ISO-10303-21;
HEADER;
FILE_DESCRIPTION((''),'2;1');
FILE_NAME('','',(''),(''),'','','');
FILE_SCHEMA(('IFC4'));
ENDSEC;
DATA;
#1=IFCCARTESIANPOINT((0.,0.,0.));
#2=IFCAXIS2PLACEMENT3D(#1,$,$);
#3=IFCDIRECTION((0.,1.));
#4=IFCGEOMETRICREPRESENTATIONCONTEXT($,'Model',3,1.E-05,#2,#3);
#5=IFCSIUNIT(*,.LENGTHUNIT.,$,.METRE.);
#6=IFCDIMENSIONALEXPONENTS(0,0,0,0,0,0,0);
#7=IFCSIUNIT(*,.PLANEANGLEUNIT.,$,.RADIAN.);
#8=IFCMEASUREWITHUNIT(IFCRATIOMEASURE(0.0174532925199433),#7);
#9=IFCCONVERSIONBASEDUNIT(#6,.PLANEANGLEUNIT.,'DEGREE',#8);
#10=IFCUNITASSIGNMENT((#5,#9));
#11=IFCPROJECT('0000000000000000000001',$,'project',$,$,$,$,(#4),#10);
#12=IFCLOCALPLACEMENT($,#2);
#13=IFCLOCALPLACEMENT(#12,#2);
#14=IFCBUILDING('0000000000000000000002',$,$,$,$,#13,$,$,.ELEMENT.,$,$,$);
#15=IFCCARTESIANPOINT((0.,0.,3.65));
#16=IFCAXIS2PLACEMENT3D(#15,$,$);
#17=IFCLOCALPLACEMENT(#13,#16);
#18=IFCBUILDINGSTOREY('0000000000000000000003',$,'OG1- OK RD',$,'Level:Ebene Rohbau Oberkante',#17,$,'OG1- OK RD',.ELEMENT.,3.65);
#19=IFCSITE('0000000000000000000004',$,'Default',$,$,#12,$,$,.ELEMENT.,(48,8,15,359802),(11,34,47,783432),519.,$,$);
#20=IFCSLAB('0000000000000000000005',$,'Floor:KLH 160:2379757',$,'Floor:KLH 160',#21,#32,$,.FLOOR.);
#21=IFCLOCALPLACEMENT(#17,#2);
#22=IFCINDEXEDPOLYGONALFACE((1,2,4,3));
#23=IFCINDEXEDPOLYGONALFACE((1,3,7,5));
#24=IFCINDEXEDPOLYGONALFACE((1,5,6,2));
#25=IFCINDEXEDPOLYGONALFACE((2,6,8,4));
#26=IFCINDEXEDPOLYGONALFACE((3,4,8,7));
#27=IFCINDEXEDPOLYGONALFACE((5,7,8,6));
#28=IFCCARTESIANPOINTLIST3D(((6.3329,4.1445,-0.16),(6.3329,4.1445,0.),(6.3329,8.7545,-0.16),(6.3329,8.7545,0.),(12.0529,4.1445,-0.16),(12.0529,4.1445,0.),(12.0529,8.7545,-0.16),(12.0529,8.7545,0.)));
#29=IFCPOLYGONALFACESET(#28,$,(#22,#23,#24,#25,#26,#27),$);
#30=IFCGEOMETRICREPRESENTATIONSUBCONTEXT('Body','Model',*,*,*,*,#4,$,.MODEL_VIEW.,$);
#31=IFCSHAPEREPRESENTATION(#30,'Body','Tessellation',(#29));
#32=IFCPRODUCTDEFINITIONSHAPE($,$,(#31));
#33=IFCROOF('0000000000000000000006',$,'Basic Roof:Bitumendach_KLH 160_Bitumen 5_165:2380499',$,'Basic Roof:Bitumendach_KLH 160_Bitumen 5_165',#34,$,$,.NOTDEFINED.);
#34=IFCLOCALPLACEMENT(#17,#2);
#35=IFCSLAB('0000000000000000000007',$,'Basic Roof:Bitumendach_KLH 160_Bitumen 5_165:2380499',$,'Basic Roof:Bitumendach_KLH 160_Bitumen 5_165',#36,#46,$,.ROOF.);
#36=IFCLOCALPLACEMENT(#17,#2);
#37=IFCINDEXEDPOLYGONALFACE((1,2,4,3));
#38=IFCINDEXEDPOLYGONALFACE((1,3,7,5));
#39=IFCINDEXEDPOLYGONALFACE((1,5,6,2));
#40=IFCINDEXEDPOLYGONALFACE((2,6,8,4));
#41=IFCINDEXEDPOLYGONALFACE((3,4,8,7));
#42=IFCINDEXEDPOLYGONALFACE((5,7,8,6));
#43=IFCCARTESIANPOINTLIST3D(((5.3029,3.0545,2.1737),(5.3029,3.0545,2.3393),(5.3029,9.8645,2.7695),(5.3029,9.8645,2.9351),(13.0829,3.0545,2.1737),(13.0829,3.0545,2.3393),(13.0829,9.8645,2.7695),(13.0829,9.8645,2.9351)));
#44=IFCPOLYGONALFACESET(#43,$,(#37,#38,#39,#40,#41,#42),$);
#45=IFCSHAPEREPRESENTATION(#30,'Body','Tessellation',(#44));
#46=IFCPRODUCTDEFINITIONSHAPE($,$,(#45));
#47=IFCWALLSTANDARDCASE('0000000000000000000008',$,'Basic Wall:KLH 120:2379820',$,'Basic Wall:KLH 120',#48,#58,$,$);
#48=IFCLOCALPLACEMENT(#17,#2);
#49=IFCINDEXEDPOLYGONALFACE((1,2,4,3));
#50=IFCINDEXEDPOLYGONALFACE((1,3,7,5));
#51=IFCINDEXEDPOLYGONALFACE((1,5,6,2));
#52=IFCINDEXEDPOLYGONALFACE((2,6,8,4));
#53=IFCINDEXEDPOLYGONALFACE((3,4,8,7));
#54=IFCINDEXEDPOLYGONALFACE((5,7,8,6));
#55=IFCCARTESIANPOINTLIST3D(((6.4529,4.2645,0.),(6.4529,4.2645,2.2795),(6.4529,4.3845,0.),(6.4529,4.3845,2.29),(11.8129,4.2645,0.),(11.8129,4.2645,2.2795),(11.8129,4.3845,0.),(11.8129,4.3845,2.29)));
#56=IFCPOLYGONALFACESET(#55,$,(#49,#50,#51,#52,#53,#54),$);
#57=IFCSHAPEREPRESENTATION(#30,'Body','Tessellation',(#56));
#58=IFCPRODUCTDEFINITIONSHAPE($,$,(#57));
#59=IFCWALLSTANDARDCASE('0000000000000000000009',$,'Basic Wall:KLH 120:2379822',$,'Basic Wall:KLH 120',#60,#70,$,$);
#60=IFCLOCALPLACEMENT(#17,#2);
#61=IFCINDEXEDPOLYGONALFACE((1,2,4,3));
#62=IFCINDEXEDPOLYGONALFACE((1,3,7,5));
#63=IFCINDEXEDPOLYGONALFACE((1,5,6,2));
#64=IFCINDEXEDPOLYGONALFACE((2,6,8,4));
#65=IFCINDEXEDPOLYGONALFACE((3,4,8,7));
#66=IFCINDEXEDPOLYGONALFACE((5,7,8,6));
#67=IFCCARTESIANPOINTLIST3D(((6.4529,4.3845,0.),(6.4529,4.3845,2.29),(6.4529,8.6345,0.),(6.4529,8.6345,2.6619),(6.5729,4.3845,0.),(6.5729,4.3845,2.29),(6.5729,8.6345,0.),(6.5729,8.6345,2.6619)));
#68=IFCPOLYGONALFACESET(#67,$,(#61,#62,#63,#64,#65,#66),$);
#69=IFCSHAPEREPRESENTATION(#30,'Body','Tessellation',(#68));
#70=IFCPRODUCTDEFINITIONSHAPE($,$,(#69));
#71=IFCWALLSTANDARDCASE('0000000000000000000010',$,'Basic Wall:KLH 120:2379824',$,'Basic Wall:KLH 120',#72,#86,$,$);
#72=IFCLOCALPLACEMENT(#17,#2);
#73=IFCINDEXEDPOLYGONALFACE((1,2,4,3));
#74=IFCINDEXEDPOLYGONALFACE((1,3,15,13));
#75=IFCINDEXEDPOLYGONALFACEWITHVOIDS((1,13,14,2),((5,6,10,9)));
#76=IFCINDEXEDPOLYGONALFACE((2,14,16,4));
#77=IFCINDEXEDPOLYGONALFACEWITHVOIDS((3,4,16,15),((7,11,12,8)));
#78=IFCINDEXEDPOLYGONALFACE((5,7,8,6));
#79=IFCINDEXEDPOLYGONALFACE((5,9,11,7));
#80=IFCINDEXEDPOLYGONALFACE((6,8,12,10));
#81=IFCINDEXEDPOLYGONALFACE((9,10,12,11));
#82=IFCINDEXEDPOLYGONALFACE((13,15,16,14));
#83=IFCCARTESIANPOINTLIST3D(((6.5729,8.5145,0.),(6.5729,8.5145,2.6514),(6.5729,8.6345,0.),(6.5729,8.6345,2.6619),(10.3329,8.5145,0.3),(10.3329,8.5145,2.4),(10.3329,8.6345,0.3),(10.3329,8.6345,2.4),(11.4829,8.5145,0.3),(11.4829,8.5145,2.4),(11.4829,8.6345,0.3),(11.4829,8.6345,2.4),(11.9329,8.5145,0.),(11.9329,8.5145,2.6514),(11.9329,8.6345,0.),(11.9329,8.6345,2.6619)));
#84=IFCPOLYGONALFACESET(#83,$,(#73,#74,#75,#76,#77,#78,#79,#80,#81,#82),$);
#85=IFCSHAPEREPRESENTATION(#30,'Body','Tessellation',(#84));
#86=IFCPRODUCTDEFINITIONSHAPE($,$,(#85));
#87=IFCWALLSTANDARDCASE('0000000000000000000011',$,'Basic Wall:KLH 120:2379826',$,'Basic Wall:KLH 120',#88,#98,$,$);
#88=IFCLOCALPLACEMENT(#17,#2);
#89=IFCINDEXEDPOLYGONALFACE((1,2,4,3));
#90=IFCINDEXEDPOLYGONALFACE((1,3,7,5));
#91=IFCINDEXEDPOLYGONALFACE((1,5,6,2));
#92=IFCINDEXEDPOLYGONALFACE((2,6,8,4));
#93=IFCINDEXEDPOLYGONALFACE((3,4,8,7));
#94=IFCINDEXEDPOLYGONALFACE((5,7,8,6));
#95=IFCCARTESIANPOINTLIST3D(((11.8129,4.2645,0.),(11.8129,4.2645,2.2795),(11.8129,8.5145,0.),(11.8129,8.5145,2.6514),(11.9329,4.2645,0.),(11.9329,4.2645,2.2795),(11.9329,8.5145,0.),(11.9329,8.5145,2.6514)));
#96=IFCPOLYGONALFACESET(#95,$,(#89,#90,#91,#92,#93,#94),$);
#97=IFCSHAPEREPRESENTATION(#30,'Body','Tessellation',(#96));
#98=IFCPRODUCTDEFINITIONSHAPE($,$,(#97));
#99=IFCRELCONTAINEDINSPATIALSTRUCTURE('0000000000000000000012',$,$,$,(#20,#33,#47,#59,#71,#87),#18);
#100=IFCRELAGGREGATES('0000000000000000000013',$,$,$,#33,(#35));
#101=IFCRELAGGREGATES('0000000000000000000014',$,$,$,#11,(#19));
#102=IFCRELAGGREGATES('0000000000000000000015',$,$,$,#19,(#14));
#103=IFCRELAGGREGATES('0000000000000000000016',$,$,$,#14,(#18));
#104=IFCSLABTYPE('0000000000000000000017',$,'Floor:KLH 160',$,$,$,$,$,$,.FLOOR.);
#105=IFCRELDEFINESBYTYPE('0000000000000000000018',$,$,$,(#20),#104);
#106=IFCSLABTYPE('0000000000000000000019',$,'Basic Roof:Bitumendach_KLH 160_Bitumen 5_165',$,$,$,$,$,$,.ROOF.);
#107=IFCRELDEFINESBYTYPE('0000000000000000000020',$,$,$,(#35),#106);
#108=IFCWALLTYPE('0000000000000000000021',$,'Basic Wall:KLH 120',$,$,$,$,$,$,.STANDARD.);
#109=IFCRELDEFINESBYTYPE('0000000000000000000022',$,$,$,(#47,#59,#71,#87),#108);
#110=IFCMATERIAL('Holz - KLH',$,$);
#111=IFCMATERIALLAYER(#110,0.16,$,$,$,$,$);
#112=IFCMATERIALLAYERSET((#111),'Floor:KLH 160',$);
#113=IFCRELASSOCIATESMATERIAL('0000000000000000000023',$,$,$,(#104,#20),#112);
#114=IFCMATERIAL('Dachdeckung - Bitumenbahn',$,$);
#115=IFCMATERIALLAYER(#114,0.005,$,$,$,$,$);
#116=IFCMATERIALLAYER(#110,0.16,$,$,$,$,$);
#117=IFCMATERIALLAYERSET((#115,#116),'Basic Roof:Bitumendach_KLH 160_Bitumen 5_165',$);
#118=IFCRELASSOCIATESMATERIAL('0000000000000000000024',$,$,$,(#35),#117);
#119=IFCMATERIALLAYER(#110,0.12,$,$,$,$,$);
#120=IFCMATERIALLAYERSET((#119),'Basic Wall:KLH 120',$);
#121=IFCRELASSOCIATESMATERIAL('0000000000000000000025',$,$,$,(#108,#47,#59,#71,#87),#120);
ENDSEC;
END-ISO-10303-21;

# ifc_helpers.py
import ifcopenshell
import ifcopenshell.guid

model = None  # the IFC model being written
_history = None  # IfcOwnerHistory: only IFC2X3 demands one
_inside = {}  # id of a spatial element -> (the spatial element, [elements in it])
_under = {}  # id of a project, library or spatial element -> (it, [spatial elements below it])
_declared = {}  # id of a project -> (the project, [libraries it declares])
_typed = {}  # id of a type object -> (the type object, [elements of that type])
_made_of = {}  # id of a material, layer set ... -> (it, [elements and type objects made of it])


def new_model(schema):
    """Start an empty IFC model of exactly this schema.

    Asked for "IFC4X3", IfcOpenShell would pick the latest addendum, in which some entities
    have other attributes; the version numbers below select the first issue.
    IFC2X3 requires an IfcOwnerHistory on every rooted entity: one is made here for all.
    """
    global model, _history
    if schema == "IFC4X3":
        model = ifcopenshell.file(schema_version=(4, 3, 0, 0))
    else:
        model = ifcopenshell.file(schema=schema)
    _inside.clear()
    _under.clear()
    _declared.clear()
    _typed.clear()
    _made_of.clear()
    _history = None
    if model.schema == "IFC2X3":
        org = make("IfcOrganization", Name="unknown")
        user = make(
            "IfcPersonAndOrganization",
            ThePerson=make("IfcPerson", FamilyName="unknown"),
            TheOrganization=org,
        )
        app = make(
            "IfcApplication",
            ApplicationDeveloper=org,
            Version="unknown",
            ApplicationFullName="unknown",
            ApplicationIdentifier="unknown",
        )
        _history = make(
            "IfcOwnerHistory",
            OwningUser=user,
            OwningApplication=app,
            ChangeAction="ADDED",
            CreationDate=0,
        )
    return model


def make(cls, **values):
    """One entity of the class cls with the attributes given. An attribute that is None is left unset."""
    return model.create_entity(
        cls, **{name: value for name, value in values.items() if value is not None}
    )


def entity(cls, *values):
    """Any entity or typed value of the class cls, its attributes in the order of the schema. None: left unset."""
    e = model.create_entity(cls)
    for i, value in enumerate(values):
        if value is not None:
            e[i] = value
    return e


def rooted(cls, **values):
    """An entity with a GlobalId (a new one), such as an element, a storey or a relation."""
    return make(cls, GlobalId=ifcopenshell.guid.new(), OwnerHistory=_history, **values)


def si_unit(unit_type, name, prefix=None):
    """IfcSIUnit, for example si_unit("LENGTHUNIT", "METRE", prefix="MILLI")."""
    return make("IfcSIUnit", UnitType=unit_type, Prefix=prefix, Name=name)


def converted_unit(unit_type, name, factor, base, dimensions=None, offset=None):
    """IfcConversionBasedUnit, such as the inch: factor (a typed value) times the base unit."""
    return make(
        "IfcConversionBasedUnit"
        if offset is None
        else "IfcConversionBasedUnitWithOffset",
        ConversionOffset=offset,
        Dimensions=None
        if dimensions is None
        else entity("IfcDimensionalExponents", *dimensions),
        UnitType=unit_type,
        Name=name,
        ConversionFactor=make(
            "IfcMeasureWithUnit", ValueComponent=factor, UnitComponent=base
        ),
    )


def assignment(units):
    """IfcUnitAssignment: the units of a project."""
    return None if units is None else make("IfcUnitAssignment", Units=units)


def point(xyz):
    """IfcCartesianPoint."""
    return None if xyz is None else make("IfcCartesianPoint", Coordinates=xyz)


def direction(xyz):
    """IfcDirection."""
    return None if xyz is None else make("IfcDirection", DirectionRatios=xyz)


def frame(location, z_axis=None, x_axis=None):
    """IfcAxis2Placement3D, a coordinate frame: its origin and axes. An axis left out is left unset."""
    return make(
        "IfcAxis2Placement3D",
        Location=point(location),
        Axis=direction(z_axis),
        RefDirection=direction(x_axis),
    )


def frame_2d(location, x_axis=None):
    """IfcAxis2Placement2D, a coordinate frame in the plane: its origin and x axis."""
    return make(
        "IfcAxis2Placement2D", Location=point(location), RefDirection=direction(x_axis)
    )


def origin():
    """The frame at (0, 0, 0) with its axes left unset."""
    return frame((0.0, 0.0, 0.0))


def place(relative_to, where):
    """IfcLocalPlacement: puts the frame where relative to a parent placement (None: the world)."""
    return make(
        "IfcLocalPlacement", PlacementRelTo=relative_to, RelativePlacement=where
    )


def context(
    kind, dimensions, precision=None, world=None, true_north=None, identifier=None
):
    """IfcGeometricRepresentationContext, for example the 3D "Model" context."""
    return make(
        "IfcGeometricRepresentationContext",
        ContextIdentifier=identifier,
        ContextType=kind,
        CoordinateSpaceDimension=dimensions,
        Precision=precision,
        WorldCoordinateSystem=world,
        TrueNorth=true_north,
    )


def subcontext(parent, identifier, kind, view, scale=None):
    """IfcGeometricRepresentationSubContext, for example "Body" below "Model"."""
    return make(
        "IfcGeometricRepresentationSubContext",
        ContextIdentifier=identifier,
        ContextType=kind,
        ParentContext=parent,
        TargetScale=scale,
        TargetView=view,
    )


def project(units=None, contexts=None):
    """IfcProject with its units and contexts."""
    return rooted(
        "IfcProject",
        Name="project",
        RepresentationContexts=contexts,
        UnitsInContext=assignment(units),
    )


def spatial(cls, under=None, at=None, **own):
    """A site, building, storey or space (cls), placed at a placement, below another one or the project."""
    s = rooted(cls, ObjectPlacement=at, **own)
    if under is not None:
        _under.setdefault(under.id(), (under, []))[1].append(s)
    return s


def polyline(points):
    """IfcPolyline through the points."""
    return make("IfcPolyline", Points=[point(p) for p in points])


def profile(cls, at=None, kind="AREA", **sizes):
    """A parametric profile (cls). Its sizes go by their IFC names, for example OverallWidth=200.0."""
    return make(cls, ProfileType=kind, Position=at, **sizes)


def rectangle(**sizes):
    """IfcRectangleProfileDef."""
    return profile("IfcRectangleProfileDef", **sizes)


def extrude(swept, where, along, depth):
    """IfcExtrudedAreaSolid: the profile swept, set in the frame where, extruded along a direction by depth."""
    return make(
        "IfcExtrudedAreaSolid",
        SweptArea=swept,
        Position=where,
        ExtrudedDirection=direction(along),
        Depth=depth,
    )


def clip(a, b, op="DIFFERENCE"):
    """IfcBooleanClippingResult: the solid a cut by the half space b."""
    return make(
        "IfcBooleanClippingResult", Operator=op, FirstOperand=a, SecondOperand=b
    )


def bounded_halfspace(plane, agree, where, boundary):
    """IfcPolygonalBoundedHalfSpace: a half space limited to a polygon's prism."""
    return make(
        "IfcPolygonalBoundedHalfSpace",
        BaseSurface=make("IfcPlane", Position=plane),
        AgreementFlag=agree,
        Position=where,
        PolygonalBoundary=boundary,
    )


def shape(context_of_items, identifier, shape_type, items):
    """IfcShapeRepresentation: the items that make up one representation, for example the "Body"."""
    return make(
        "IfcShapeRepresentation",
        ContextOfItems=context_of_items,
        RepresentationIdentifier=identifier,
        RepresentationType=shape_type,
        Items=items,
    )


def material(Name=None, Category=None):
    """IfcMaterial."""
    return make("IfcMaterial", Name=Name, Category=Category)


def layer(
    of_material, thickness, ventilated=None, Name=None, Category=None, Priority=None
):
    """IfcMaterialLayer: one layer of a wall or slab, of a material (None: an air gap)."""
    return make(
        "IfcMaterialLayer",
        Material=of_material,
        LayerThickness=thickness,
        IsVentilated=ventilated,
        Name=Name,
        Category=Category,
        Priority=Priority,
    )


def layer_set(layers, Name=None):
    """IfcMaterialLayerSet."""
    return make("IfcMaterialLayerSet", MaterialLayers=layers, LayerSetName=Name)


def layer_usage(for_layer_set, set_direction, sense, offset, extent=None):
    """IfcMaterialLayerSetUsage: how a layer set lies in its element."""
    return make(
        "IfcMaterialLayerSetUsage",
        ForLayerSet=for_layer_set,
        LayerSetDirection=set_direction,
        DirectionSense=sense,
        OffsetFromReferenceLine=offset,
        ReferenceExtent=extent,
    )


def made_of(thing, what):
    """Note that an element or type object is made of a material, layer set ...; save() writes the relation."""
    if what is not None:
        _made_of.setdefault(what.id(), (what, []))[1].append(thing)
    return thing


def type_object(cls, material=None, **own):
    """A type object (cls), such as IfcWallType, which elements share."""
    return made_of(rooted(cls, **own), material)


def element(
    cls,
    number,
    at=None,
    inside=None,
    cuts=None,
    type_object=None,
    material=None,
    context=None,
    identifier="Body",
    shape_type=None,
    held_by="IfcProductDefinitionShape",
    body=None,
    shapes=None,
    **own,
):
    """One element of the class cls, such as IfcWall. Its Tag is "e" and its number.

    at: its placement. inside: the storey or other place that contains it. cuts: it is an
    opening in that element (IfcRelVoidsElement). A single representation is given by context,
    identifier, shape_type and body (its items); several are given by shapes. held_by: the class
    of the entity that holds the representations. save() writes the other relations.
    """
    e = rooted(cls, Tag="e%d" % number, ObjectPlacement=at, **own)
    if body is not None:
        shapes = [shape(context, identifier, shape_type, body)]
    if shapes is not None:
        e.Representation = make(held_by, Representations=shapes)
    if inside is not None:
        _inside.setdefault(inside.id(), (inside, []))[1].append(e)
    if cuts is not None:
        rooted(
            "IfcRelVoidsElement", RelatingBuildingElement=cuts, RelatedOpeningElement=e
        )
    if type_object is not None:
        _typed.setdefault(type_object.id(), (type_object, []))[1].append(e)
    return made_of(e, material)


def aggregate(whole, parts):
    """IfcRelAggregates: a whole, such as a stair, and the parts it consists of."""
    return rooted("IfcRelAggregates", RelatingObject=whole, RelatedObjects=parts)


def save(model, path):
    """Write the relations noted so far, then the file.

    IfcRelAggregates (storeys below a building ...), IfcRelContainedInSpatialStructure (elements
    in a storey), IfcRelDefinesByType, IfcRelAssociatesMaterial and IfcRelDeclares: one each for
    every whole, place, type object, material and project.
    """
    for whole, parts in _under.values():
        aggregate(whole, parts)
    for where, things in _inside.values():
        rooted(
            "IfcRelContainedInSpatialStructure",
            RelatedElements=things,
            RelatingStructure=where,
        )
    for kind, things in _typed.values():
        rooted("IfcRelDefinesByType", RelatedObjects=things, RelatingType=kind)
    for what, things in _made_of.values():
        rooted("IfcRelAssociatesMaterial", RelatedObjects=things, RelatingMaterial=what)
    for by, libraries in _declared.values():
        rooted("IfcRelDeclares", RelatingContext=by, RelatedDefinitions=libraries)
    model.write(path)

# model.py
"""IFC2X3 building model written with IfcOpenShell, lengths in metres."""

from ifc_helpers import new_model, entity, si_unit, converted_unit, direction, frame, frame_2d, origin, place, context, subcontext, project, spatial, polyline, rectangle, extrude, clip, bounded_halfspace, material, layer, layer_set, layer_usage, type_object, element, aggregate, save


model = new_model("IFC2X3")

# Units and contexts
model_context = context("Model", 3, precision=1e-05, world=origin(), true_north=direction((0.0, 1.0)))
body_context = subcontext(model_context, "Body", "Model", "MODEL_VIEW")
ifc_project = project(units=[si_unit("LENGTHUNIT", "METRE"), converted_unit("PLANEANGLEUNIT", "DEGREE", entity("IfcRatioMeasure", 0.0174532925199433), si_unit("PLANEANGLEUNIT", "RADIAN"), dimensions=[0, 0, 0, 0, 0, 0, 0])], contexts=[model_context])

# Site, building, storey
site_placement = place(None, origin())
site = spatial("IfcSite", under=ifc_project, at=site_placement, Name="Default", CompositionType="ELEMENT", RefLatitude=(48, 8, 15, 359802), RefLongitude=(11, 34, 47, 783432), RefElevation=519.0)
building_placement = place(site_placement, origin())
building = spatial("IfcBuilding", under=site, at=building_placement, CompositionType="ELEMENT")
storey_placement = place(building_placement, frame((0.0, 0.0, 3.65)))
storey = spatial("IfcBuildingStorey", under=building, at=storey_placement, Name="OG1- OK RD", ObjectType="Level:Ebene Rohbau Oberkante", LongName="OG1- OK RD", CompositionType="ELEMENT", Elevation=3.65)

# Slab
ifc_material_1 = material(Name="Holz - KLH")
ifc_layer_1 = layer(ifc_material_1, 0.16)
ifc_layer_set_1 = layer_set([ifc_layer_1], Name="Floor:KLH 160")
ifc_layer_usage_1 = layer_usage(ifc_layer_set_1, "AXIS3", "POSITIVE", 0.0)
slab_type_1 = type_object("IfcSlabType", Name="Floor:KLH 160", PredefinedType="FLOOR", material=ifc_layer_set_1)
slab_1_placement = place(storey_placement, origin())
element("IfcSlab", 1, at=slab_1_placement, inside=storey, type_object=slab_type_1, material=ifc_layer_usage_1, Name="Floor:KLH 160:2379757", ObjectType="Floor:KLH 160", PredefinedType="FLOOR", context=body_context, shape_type="SweptSolid", body=[
    extrude(rectangle(XDim=4.61, YDim=5.72, at=frame_2d((0.0, 0.0), x_axis=(1.0, 0.0))), frame((9.1929, 6.4495, 0.0), z_axis=(0.0, 0.0, -1.0), x_axis=(0.0, 1.0, 0.0)), (0.0, 0.0, 1.0), 0.16),
])

# Roof, slab
roof_placement = place(storey_placement, frame((5.3029, 3.0545, 2.1737)))
roof = element("IfcRoof", 2, at=roof_placement, inside=storey, Name="Basic Roof:Bitumendach_KLH 160_Bitumen 5_165:2380499", ObjectType="Basic Roof:Bitumendach_KLH 160_Bitumen 5_165", ShapeType="NOTDEFINED")
ifc_material_2 = material(Name="Dachdeckung - Bitumenbahn")
ifc_layer_2 = layer(ifc_material_2, 0.005)
ifc_layer_3 = layer(ifc_material_1, 0.16)
ifc_layer_set_2 = layer_set([ifc_layer_2, ifc_layer_3], Name="Basic Roof:Bitumendach_KLH 160_Bitumen 5_165")
slab_type_2 = type_object("IfcSlabType", Name="Basic Roof:Bitumendach_KLH 160_Bitumen 5_165", PredefinedType="ROOF")
slab_2_placement = place(roof_placement, origin())
slab_2 = element("IfcSlab", 3, at=slab_2_placement, type_object=slab_type_2, material=ifc_layer_set_2, Name="Basic Roof:Bitumendach_KLH 160_Bitumen 5_165:2380499", ObjectType="Basic Roof:Bitumendach_KLH 160_Bitumen 5_165", PredefinedType="ROOF", context=body_context, shape_type="SweptSolid", body=[
    extrude(rectangle(XDim=6.836, YDim=7.78, at=frame_2d((0.0, 0.0), x_axis=(0.0, -1.0))), frame((3.89, 3.405, 0.2979), z_axis=(0.0, -0.087156, 0.996195), x_axis=(1.0, 0.0, 0.0)), (0.0, 0.087156, 0.996195), 0.1656),
])
aggregate(roof, [slab_2])

# Walls
ifc_layer_4 = layer(ifc_material_1, 0.12)
ifc_layer_set_3 = layer_set([ifc_layer_4], Name="Basic Wall:KLH 120")
ifc_layer_usage_2 = layer_usage(ifc_layer_set_3, "AXIS2", "NEGATIVE", 0.06)
wall_type = type_object("IfcWallType", Name="Basic Wall:KLH 120", PredefinedType="STANDARD", material=ifc_layer_set_3)
wall_1_placement = place(storey_placement, frame((6.4529, 4.3245, 0.0)))
element("IfcWallStandardCase", 4, at=wall_1_placement, inside=storey, type_object=wall_type, material=ifc_layer_usage_2, Name="Basic Wall:KLH 120:2379820", ObjectType="Basic Wall:KLH 120", context=body_context, shape_type="Clipping", body=[
    clip(extrude(rectangle(XDim=5.36, YDim=0.12, at=frame_2d((2.68, 0.0), x_axis=(-1.0, 0.0))), origin(), (0.0, 0.0, 1.0), 2.29), bounded_halfspace(frame((0.0, -0.06, 2.2795), z_axis=(0.0, -0.087156, 0.996195), x_axis=(1.0, 0.0, 0.0)), False, frame((0.0, -0.06, 2.2795)), polyline([(0.0, 0.0), (5.36, 0.0), (5.36, 0.12), (0.12, 0.12), (0.0, 0.12), (0.0, 0.0)]))),
])
ifc_layer_usage_3 = layer_usage(ifc_layer_set_3, "AXIS2", "NEGATIVE", 0.06)
wall_2_placement = place(storey_placement, frame((6.5129, 8.6345, 0.0), z_axis=(0.0, 0.0, 1.0), x_axis=(0.0, -1.0, 0.0)))
element("IfcWallStandardCase", 5, at=wall_2_placement, inside=storey, type_object=wall_type, material=ifc_layer_usage_3, Name="Basic Wall:KLH 120:2379822", ObjectType="Basic Wall:KLH 120", context=body_context, shape_type="Clipping", body=[
    clip(extrude(rectangle(XDim=4.25, YDim=0.12, at=frame_2d((2.125, 0.0), x_axis=(-1.0, 0.0))), origin(), (0.0, 0.0, 1.0), 2.6619), bounded_halfspace(frame((0.0, -0.06, 2.6619), z_axis=(0.087156, 0.0, 0.996195), x_axis=(0.0, 1.0, 0.0)), False, frame((0.0, -0.06, 2.6619)), polyline([(0.0, 0.0), (4.25, 0.0), (4.25, 0.12), (0.12, 0.12), (0.0, 0.12), (0.0, 0.0)]))),
])

# Wall, opening
ifc_layer_usage_4 = layer_usage(ifc_layer_set_3, "AXIS2", "NEGATIVE", 0.06)
wall_3_placement = place(storey_placement, frame((11.9329, 8.5745, 0.0), z_axis=(0.0, 0.0, 1.0), x_axis=(-1.0, 0.0, 0.0)))
wall_3 = element("IfcWallStandardCase", 6, at=wall_3_placement, inside=storey, type_object=wall_type, material=ifc_layer_usage_4, Name="Basic Wall:KLH 120:2379824", ObjectType="Basic Wall:KLH 120", context=body_context, shape_type="Clipping", body=[
    clip(extrude(rectangle(XDim=5.36, YDim=0.12, at=frame_2d((2.68, 0.0), x_axis=(-1.0, 0.0))), origin(), (0.0, 0.0, 1.0), 2.6619), bounded_halfspace(frame((0.0, -0.06, 2.6619), z_axis=(0.0, 0.087156, 0.996195), x_axis=(-1.0, 0.0, 0.0)), False, frame((0.0, -0.06, 2.6619)), polyline([(0.0, 0.0), (5.36, 0.0), (5.36, 0.12), (0.12, 0.12), (0.0, 0.12), (0.0, 0.0)]))),
])
opening_placement = place(wall_3_placement, frame((0.45, -0.06, 0.3)))
element("IfcOpeningElement", 7, at=opening_placement, cuts=wall_3, ObjectType="Opening", context=body_context, shape_type="SweptSolid", body=[
    extrude(rectangle(XDim=2.1, YDim=1.15, at=frame_2d((1.05, 0.575), x_axis=(-1.0, 0.0))), frame((0.0, 0.0, 0.0), z_axis=(0.0, 1.0, 0.0), x_axis=(0.0, 0.0, 1.0)), (0.0, 0.0, 1.0), 0.12),
])

# Wall
ifc_layer_usage_5 = layer_usage(ifc_layer_set_3, "AXIS2", "NEGATIVE", 0.06)
wall_4_placement = place(storey_placement, frame((11.8729, 4.2645, 0.0), z_axis=(0.0, 0.0, 1.0), x_axis=(0.0, 1.0, 0.0)))
element("IfcWallStandardCase", 8, at=wall_4_placement, inside=storey, type_object=wall_type, material=ifc_layer_usage_5, Name="Basic Wall:KLH 120:2379826", ObjectType="Basic Wall:KLH 120", context=body_context, shape_type="Clipping", body=[
    clip(extrude(rectangle(XDim=4.25, YDim=0.12, at=frame_2d((2.125, 0.0), x_axis=(-1.0, 0.0))), origin(), (0.0, 0.0, 1.0), 2.6514), bounded_halfspace(frame((0.0, -0.06, 2.2795), z_axis=(-0.087156, 0.0, 0.996195), x_axis=(0.0, -1.0, 0.0)), False, frame((0.0, -0.06, 2.2795)), polyline([(0.0, 0.0), (4.25, 0.0), (4.25, 0.12), (0.12, 0.12), (0.0, 0.12), (0.0, 0.0)]))),
])

save(model, "model.ifc")
